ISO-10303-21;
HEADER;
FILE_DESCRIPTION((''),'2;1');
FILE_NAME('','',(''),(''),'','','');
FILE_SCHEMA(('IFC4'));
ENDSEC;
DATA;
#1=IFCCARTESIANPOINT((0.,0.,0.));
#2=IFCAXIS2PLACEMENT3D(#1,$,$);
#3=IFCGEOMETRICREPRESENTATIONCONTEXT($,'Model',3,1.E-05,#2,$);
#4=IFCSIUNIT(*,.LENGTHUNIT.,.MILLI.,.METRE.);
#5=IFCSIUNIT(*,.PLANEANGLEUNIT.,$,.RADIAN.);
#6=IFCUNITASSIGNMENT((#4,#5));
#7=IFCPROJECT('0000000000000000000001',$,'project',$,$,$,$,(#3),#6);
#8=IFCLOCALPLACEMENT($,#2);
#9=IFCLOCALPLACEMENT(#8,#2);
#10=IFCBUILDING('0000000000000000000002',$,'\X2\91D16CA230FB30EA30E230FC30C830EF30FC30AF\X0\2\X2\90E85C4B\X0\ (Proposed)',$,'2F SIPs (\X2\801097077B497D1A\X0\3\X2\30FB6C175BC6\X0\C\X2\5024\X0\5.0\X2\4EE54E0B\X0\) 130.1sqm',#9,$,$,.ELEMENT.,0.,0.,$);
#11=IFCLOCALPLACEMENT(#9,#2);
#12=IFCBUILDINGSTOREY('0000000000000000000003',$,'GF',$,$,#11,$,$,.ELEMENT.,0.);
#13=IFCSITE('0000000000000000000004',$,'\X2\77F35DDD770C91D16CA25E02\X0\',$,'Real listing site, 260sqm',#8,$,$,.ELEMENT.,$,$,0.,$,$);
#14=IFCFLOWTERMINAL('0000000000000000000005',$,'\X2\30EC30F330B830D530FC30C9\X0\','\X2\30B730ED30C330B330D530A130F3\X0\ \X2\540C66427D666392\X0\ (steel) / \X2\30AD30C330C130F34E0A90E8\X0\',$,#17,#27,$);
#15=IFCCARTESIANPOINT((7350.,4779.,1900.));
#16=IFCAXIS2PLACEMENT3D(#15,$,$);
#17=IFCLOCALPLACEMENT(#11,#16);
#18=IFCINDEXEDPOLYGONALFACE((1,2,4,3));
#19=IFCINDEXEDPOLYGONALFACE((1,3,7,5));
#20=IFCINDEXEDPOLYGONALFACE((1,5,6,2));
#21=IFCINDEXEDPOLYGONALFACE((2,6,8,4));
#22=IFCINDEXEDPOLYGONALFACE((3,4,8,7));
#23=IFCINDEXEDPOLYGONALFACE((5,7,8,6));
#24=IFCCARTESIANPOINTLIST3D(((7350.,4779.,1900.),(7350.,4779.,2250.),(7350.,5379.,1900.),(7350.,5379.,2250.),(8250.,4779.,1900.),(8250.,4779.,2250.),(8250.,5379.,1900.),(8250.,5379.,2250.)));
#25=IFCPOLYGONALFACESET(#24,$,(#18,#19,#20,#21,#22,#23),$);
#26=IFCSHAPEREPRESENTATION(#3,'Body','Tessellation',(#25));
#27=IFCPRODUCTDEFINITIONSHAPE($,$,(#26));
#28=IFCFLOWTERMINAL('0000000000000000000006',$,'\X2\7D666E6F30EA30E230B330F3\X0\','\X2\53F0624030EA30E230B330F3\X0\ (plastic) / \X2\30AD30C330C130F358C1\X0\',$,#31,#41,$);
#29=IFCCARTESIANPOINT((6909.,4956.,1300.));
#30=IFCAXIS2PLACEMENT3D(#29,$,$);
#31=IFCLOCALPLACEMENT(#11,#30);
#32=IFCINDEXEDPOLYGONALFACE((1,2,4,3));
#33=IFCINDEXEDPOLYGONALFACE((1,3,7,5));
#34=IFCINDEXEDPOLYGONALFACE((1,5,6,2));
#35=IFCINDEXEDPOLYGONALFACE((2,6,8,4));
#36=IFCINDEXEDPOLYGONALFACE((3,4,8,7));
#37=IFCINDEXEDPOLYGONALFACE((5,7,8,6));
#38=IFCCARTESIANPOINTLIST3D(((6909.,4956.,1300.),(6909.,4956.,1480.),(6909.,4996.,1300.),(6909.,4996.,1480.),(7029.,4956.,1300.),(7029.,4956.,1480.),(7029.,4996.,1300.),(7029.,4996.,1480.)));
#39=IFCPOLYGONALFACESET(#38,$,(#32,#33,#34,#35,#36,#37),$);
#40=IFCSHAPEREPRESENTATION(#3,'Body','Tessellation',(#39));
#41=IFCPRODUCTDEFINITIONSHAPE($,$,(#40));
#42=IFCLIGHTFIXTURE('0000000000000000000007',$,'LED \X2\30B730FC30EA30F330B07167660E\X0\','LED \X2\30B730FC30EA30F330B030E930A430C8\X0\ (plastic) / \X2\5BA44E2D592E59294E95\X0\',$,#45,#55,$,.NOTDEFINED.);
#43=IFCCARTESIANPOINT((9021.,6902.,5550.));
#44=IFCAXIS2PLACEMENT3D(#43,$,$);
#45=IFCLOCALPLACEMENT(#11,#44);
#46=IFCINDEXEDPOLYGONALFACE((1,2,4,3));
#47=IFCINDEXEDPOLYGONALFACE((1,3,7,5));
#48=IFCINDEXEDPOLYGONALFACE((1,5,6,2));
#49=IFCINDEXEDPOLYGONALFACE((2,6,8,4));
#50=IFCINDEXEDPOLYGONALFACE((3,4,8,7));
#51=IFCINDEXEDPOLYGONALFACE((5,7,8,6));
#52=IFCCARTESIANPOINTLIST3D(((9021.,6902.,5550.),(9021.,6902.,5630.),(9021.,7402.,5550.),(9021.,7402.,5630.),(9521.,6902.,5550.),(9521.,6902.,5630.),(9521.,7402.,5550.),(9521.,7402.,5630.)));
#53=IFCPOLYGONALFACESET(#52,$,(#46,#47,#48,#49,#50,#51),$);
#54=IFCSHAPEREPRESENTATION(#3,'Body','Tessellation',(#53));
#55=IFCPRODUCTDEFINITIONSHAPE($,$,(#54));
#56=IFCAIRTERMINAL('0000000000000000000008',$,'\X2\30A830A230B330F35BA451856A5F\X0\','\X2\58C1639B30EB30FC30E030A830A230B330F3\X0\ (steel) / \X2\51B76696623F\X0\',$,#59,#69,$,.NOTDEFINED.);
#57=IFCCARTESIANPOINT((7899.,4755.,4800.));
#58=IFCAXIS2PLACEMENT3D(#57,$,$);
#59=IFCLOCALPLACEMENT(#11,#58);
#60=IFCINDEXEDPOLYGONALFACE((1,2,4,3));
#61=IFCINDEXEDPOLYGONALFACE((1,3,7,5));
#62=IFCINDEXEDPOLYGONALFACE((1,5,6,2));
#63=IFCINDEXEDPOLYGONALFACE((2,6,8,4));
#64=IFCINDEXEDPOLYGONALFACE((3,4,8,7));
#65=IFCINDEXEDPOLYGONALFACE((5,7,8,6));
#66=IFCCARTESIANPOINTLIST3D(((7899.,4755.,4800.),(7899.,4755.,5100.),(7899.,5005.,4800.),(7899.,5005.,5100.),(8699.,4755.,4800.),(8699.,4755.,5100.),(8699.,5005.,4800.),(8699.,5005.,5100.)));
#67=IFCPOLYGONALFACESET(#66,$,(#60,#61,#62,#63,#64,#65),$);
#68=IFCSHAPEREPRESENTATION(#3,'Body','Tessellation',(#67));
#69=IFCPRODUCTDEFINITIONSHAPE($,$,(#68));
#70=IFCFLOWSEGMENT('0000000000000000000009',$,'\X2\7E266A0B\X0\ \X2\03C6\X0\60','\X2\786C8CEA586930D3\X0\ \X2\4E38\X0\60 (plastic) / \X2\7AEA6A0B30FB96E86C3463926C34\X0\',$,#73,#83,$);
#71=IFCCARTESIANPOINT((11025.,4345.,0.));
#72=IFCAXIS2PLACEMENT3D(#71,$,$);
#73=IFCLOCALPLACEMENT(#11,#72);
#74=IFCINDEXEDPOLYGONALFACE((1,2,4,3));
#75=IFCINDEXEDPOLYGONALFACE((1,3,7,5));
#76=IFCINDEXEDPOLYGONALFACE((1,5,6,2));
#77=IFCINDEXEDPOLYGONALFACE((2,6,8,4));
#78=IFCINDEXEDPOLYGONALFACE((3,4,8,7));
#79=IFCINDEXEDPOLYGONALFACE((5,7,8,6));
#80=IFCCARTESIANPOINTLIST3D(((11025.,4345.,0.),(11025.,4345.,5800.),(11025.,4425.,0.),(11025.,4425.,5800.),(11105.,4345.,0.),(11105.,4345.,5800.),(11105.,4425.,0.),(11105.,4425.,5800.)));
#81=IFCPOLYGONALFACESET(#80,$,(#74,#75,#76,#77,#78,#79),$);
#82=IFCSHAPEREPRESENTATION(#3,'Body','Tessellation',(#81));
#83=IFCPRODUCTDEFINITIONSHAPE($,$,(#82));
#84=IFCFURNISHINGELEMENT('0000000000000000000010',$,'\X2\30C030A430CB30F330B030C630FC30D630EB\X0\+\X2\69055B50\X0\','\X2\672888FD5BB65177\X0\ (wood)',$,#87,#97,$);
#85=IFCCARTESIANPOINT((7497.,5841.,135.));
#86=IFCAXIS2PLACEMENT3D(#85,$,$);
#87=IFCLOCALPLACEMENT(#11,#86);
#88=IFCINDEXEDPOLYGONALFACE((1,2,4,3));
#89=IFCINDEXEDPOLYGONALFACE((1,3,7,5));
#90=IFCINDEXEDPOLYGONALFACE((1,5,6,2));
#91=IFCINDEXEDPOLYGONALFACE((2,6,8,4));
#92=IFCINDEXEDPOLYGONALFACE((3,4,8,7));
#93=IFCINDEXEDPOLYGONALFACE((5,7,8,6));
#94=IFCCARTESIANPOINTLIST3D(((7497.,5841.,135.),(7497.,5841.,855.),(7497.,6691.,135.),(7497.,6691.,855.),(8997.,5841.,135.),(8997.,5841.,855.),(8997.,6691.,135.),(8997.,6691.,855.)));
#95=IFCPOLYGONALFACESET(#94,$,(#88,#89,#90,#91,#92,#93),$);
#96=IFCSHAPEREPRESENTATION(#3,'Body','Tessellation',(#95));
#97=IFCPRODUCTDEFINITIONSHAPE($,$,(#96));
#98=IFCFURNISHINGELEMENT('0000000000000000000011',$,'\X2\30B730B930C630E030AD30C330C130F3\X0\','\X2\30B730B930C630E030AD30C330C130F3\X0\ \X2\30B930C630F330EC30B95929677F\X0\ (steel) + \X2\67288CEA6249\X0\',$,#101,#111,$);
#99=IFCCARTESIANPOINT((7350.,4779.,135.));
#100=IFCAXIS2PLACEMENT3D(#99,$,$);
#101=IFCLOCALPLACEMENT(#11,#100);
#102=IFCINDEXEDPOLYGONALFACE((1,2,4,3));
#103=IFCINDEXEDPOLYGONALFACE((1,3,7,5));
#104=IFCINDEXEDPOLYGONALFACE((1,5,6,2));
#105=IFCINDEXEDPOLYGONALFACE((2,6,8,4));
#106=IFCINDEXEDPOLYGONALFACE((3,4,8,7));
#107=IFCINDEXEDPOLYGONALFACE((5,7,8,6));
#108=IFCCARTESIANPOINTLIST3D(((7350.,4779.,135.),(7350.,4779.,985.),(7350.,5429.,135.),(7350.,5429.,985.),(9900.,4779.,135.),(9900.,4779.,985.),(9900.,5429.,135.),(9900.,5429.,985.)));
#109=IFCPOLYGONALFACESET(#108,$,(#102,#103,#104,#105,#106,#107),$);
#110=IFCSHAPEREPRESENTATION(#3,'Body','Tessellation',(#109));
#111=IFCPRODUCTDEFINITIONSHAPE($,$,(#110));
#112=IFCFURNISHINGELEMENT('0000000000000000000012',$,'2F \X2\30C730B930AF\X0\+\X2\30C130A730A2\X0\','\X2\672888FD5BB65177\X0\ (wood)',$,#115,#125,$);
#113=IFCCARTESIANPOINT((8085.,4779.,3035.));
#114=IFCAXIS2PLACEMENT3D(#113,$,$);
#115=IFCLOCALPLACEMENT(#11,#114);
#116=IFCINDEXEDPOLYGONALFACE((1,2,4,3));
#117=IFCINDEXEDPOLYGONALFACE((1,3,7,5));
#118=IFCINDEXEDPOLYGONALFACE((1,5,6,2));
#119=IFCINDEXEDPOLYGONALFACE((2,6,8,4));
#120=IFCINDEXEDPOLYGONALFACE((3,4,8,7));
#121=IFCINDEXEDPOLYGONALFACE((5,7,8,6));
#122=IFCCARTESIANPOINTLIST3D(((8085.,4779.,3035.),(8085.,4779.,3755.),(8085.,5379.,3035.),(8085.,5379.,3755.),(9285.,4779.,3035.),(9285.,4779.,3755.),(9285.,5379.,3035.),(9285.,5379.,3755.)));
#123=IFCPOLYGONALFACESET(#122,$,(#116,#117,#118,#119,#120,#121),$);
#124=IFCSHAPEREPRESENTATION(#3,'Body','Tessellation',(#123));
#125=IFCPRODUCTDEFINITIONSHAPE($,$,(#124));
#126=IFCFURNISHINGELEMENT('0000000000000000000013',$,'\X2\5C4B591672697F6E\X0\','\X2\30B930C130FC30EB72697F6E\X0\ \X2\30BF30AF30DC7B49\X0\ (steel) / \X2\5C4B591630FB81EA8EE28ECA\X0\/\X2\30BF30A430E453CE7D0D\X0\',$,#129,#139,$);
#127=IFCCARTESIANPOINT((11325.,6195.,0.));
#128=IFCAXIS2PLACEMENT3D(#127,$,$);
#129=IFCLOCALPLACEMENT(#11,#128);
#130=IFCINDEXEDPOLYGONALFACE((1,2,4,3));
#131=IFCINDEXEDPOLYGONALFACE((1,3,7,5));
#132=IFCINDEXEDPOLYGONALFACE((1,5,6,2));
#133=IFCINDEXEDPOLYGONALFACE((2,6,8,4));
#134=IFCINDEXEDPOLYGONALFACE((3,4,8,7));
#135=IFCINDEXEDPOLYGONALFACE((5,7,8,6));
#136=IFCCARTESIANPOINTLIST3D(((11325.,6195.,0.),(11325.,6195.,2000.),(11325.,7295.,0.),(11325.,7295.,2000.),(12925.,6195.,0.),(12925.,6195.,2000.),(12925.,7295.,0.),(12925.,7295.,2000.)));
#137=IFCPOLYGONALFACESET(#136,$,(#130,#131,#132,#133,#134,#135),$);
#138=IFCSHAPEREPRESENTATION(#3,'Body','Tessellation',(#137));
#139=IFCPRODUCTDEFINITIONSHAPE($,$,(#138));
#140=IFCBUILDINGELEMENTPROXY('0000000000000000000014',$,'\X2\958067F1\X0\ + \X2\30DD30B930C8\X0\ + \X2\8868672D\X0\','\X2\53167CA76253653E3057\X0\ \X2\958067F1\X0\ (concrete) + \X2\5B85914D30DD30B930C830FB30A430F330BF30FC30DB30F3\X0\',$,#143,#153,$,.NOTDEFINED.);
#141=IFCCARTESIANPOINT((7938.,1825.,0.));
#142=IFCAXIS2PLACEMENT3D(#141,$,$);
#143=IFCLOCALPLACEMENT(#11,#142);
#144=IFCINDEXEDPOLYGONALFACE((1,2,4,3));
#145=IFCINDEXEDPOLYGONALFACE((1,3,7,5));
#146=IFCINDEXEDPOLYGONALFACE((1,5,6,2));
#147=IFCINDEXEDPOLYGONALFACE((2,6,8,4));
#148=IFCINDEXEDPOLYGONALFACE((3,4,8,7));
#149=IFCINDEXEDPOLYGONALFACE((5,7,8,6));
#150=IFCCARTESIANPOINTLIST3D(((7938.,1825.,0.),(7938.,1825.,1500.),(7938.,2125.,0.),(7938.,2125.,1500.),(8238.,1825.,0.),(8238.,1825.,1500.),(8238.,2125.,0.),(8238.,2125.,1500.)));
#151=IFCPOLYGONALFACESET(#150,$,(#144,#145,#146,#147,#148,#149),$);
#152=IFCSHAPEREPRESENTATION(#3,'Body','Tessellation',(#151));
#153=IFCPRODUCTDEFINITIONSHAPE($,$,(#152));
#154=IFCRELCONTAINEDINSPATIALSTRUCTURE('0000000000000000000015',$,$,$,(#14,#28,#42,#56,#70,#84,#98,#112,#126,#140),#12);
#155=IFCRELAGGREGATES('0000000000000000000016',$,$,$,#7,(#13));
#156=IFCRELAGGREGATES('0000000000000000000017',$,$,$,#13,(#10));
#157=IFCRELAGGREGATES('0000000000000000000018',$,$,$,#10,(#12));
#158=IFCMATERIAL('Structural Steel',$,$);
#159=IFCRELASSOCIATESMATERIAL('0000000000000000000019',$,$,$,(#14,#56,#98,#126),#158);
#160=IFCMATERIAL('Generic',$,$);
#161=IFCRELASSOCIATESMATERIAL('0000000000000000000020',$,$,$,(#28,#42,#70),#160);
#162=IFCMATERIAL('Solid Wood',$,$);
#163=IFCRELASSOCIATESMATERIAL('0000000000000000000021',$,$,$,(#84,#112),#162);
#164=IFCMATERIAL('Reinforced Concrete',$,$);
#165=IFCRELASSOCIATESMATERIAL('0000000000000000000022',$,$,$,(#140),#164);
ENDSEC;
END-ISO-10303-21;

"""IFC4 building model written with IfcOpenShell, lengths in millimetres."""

from ifc_helpers import new_model, si_unit, frame, frame_2d, origin, place, context, project, spatial, rectangle, extrude, material, element, save


model = new_model("IFC4")

# Units and contexts
model_context = context("Model", 3, precision=1e-05, world=origin())
ifc_project = project(units=[si_unit("LENGTHUNIT", "METRE", prefix="MILLI"), si_unit("PLANEANGLEUNIT", "RADIAN")], contexts=[model_context])

# Site, building, storey
site_placement = place(None, origin())
site = spatial("IfcSite", under=ifc_project, at=site_placement, Name="石川県金沢市", ObjectType="Real listing site, 260sqm", CompositionType="ELEMENT", RefElevation=0.0)
building_placement = place(site_placement, origin())
building = spatial("IfcBuilding", under=site, at=building_placement, Name="金沢・リモートワーク2部屋 (Proposed)", ObjectType="2F SIPs (耐震等級3・気密C値5.0以下) 130.1sqm", CompositionType="ELEMENT", ElevationOfRefHeight=0.0, ElevationOfTerrain=0.0)
storey_placement = place(building_placement, origin())
storey = spatial("IfcBuildingStorey", under=building, at=storey_placement, Name="GF", CompositionType="ELEMENT", Elevation=0.0)

# Shared definitions
ifc_material_1 = material(Name="Solid Wood")

# Shared definitions
ifc_material_2 = material(Name="Reinforced Concrete")

# Shared definitions
ifc_material_3 = material(Name="Structural Steel")

# Flow terminals
flow_terminal_1_placement = place(storey_placement, frame((7350.0, 4779.0, 1900.0)))
element("IfcFlowTerminal", 1, at=flow_terminal_1_placement, inside=storey, material=ifc_material_3, Name="レンジフード", Description="シロッコファン 同時給排 (steel) / キッチン上部", context=model_context, shape_type="SweptSolid", body=[
    extrude(rectangle(XDim=900.0, YDim=600.0, at=frame_2d((450.0, 300.0))), frame((7350.0, 4779.0, 1900.0)), (0.0, 0.0, 1.0), 350.0),
])
ifc_material_4 = material(Name="Generic")
flow_terminal_2_placement = place(storey_placement, frame((6909.0, 4956.0, 1300.0)))
element("IfcFlowTerminal", 2, at=flow_terminal_2_placement, inside=storey, material=ifc_material_4, Name="給湯リモコン", Description="台所リモコン (plastic) / キッチン壁", context=model_context, shape_type="SweptSolid", body=[
    extrude(rectangle(XDim=120.0, YDim=40.0, at=frame_2d((60.0, 20.0))), frame((6909.0, 4956.0, 1300.0)), (0.0, 0.0, 1.0), 180.0),
])

# Light fixture
light_fixture_placement = place(storey_placement, frame((9021.0, 6902.0, 5550.0)))
element("IfcLightFixture", 3, at=light_fixture_placement, inside=storey, material=ifc_material_4, Name="LED シーリング照明", Description="LED シーリングライト (plastic) / 室中央天井", PredefinedType="NOTDEFINED", context=model_context, shape_type="SweptSolid", body=[
    extrude(rectangle(XDim=500.0, YDim=500.0, at=frame_2d((250.0, 250.0))), frame((9021.0, 6902.0, 5550.0)), (0.0, 0.0, 1.0), 80.0),
])

# Air terminal
air_terminal_placement = place(storey_placement, frame((7899.0, 4755.0, 4800.0)))
element("IfcAirTerminal", 4, at=air_terminal_placement, inside=storey, material=ifc_material_3, Name="エアコン室内機", Description="壁掛ルームエアコン (steel) / 冷暖房", PredefinedType="NOTDEFINED", context=model_context, shape_type="SweptSolid", body=[
    extrude(rectangle(XDim=800.0, YDim=250.0, at=frame_2d((400.0, 125.0))), frame((7899.0, 4755.0, 4800.0)), (0.0, 0.0, 1.0), 300.0),
])

# Flow segment
flow_segment_placement = place(storey_placement, frame((11025.0, 4345.0, 0.0)))
element("IfcFlowSegment", 5, at=flow_segment_placement, inside=storey, material=ifc_material_4, Name="縦樋 φ60", Description="硬質塩ビ 丸60 (plastic) / 竪樋・雨水排水", context=model_context, shape_type="SweptSolid", body=[
    extrude(rectangle(XDim=80.0, YDim=80.0, at=frame_2d((40.0, 40.0))), frame((11025.0, 4345.0, 0.0)), (0.0, 0.0, 1.0), 5800.0),
])

# Furnishing elements
furnishing_1_placement = place(storey_placement, frame((7497.0, 5841.0, 135.0)))
element("IfcFurnishingElement", 6, at=furnishing_1_placement, inside=storey, material=ifc_material_1, Name="ダイニングテーブル+椅子", Description="木製家具 (wood)", context=model_context, shape_type="SweptSolid", body=[
    extrude(rectangle(XDim=1500.0, YDim=850.0, at=frame_2d((750.0, 425.0))), frame((7497.0, 5841.0, 135.0)), (0.0, 0.0, 1.0), 720.0),
])
furnishing_2_placement = place(storey_placement, frame((7350.0, 4779.0, 135.0)))
element("IfcFurnishingElement", 7, at=furnishing_2_placement, inside=storey, material=ifc_material_3, Name="システムキッチン", Description="システムキッチン ステンレス天板 (steel) + 木質扉", context=model_context, shape_type="SweptSolid", body=[
    extrude(rectangle(XDim=2550.0, YDim=650.0, at=frame_2d((1275.0, 325.0))), frame((7350.0, 4779.0, 135.0)), (0.0, 0.0, 1.0), 850.0),
])
furnishing_3_placement = place(storey_placement, frame((8085.0, 4779.0, 3035.0)))
element("IfcFurnishingElement", 8, at=furnishing_3_placement, inside=storey, material=ifc_material_1, Name="2F デスク+チェア", Description="木製家具 (wood)", context=model_context, shape_type="SweptSolid", body=[
    extrude(rectangle(XDim=1200.0, YDim=600.0, at=frame_2d((600.0, 300.0))), frame((8085.0, 4779.0, 3035.0)), (0.0, 0.0, 1.0), 720.0),
])
furnishing_4_placement = place(storey_placement, frame((11325.0, 6195.0, 0.0)))
element("IfcFurnishingElement", 9, at=furnishing_4_placement, inside=storey, material=ifc_material_3, Name="屋外物置", Description="スチール物置 タクボ等 (steel) / 屋外・自転車/タイヤ収納", context=model_context, shape_type="SweptSolid", body=[
    extrude(rectangle(XDim=1600.0, YDim=1100.0, at=frame_2d((800.0, 550.0))), frame((11325.0, 6195.0, 0.0)), (0.0, 0.0, 1.0), 2000.0),
])

# Building element proxy
proxy_placement = place(storey_placement, frame((7938.0, 1825.0, 0.0)))
element("IfcBuildingElementProxy", 10, at=proxy_placement, inside=storey, material=ifc_material_2, Name="門柱 + ポスト + 表札", Description="化粧打放し 門柱 (concrete) + 宅配ポスト・インターホン", PredefinedType="NOTDEFINED", context=model_context, shape_type="SweptSolid", body=[
    extrude(rectangle(XDim=300.0, YDim=300.0, at=frame_2d((150.0, 150.0))), frame((7938.0, 1825.0, 0.0)), (0.0, 0.0, 1.0), 1500.0),
])

save(model, "model.ifc")
